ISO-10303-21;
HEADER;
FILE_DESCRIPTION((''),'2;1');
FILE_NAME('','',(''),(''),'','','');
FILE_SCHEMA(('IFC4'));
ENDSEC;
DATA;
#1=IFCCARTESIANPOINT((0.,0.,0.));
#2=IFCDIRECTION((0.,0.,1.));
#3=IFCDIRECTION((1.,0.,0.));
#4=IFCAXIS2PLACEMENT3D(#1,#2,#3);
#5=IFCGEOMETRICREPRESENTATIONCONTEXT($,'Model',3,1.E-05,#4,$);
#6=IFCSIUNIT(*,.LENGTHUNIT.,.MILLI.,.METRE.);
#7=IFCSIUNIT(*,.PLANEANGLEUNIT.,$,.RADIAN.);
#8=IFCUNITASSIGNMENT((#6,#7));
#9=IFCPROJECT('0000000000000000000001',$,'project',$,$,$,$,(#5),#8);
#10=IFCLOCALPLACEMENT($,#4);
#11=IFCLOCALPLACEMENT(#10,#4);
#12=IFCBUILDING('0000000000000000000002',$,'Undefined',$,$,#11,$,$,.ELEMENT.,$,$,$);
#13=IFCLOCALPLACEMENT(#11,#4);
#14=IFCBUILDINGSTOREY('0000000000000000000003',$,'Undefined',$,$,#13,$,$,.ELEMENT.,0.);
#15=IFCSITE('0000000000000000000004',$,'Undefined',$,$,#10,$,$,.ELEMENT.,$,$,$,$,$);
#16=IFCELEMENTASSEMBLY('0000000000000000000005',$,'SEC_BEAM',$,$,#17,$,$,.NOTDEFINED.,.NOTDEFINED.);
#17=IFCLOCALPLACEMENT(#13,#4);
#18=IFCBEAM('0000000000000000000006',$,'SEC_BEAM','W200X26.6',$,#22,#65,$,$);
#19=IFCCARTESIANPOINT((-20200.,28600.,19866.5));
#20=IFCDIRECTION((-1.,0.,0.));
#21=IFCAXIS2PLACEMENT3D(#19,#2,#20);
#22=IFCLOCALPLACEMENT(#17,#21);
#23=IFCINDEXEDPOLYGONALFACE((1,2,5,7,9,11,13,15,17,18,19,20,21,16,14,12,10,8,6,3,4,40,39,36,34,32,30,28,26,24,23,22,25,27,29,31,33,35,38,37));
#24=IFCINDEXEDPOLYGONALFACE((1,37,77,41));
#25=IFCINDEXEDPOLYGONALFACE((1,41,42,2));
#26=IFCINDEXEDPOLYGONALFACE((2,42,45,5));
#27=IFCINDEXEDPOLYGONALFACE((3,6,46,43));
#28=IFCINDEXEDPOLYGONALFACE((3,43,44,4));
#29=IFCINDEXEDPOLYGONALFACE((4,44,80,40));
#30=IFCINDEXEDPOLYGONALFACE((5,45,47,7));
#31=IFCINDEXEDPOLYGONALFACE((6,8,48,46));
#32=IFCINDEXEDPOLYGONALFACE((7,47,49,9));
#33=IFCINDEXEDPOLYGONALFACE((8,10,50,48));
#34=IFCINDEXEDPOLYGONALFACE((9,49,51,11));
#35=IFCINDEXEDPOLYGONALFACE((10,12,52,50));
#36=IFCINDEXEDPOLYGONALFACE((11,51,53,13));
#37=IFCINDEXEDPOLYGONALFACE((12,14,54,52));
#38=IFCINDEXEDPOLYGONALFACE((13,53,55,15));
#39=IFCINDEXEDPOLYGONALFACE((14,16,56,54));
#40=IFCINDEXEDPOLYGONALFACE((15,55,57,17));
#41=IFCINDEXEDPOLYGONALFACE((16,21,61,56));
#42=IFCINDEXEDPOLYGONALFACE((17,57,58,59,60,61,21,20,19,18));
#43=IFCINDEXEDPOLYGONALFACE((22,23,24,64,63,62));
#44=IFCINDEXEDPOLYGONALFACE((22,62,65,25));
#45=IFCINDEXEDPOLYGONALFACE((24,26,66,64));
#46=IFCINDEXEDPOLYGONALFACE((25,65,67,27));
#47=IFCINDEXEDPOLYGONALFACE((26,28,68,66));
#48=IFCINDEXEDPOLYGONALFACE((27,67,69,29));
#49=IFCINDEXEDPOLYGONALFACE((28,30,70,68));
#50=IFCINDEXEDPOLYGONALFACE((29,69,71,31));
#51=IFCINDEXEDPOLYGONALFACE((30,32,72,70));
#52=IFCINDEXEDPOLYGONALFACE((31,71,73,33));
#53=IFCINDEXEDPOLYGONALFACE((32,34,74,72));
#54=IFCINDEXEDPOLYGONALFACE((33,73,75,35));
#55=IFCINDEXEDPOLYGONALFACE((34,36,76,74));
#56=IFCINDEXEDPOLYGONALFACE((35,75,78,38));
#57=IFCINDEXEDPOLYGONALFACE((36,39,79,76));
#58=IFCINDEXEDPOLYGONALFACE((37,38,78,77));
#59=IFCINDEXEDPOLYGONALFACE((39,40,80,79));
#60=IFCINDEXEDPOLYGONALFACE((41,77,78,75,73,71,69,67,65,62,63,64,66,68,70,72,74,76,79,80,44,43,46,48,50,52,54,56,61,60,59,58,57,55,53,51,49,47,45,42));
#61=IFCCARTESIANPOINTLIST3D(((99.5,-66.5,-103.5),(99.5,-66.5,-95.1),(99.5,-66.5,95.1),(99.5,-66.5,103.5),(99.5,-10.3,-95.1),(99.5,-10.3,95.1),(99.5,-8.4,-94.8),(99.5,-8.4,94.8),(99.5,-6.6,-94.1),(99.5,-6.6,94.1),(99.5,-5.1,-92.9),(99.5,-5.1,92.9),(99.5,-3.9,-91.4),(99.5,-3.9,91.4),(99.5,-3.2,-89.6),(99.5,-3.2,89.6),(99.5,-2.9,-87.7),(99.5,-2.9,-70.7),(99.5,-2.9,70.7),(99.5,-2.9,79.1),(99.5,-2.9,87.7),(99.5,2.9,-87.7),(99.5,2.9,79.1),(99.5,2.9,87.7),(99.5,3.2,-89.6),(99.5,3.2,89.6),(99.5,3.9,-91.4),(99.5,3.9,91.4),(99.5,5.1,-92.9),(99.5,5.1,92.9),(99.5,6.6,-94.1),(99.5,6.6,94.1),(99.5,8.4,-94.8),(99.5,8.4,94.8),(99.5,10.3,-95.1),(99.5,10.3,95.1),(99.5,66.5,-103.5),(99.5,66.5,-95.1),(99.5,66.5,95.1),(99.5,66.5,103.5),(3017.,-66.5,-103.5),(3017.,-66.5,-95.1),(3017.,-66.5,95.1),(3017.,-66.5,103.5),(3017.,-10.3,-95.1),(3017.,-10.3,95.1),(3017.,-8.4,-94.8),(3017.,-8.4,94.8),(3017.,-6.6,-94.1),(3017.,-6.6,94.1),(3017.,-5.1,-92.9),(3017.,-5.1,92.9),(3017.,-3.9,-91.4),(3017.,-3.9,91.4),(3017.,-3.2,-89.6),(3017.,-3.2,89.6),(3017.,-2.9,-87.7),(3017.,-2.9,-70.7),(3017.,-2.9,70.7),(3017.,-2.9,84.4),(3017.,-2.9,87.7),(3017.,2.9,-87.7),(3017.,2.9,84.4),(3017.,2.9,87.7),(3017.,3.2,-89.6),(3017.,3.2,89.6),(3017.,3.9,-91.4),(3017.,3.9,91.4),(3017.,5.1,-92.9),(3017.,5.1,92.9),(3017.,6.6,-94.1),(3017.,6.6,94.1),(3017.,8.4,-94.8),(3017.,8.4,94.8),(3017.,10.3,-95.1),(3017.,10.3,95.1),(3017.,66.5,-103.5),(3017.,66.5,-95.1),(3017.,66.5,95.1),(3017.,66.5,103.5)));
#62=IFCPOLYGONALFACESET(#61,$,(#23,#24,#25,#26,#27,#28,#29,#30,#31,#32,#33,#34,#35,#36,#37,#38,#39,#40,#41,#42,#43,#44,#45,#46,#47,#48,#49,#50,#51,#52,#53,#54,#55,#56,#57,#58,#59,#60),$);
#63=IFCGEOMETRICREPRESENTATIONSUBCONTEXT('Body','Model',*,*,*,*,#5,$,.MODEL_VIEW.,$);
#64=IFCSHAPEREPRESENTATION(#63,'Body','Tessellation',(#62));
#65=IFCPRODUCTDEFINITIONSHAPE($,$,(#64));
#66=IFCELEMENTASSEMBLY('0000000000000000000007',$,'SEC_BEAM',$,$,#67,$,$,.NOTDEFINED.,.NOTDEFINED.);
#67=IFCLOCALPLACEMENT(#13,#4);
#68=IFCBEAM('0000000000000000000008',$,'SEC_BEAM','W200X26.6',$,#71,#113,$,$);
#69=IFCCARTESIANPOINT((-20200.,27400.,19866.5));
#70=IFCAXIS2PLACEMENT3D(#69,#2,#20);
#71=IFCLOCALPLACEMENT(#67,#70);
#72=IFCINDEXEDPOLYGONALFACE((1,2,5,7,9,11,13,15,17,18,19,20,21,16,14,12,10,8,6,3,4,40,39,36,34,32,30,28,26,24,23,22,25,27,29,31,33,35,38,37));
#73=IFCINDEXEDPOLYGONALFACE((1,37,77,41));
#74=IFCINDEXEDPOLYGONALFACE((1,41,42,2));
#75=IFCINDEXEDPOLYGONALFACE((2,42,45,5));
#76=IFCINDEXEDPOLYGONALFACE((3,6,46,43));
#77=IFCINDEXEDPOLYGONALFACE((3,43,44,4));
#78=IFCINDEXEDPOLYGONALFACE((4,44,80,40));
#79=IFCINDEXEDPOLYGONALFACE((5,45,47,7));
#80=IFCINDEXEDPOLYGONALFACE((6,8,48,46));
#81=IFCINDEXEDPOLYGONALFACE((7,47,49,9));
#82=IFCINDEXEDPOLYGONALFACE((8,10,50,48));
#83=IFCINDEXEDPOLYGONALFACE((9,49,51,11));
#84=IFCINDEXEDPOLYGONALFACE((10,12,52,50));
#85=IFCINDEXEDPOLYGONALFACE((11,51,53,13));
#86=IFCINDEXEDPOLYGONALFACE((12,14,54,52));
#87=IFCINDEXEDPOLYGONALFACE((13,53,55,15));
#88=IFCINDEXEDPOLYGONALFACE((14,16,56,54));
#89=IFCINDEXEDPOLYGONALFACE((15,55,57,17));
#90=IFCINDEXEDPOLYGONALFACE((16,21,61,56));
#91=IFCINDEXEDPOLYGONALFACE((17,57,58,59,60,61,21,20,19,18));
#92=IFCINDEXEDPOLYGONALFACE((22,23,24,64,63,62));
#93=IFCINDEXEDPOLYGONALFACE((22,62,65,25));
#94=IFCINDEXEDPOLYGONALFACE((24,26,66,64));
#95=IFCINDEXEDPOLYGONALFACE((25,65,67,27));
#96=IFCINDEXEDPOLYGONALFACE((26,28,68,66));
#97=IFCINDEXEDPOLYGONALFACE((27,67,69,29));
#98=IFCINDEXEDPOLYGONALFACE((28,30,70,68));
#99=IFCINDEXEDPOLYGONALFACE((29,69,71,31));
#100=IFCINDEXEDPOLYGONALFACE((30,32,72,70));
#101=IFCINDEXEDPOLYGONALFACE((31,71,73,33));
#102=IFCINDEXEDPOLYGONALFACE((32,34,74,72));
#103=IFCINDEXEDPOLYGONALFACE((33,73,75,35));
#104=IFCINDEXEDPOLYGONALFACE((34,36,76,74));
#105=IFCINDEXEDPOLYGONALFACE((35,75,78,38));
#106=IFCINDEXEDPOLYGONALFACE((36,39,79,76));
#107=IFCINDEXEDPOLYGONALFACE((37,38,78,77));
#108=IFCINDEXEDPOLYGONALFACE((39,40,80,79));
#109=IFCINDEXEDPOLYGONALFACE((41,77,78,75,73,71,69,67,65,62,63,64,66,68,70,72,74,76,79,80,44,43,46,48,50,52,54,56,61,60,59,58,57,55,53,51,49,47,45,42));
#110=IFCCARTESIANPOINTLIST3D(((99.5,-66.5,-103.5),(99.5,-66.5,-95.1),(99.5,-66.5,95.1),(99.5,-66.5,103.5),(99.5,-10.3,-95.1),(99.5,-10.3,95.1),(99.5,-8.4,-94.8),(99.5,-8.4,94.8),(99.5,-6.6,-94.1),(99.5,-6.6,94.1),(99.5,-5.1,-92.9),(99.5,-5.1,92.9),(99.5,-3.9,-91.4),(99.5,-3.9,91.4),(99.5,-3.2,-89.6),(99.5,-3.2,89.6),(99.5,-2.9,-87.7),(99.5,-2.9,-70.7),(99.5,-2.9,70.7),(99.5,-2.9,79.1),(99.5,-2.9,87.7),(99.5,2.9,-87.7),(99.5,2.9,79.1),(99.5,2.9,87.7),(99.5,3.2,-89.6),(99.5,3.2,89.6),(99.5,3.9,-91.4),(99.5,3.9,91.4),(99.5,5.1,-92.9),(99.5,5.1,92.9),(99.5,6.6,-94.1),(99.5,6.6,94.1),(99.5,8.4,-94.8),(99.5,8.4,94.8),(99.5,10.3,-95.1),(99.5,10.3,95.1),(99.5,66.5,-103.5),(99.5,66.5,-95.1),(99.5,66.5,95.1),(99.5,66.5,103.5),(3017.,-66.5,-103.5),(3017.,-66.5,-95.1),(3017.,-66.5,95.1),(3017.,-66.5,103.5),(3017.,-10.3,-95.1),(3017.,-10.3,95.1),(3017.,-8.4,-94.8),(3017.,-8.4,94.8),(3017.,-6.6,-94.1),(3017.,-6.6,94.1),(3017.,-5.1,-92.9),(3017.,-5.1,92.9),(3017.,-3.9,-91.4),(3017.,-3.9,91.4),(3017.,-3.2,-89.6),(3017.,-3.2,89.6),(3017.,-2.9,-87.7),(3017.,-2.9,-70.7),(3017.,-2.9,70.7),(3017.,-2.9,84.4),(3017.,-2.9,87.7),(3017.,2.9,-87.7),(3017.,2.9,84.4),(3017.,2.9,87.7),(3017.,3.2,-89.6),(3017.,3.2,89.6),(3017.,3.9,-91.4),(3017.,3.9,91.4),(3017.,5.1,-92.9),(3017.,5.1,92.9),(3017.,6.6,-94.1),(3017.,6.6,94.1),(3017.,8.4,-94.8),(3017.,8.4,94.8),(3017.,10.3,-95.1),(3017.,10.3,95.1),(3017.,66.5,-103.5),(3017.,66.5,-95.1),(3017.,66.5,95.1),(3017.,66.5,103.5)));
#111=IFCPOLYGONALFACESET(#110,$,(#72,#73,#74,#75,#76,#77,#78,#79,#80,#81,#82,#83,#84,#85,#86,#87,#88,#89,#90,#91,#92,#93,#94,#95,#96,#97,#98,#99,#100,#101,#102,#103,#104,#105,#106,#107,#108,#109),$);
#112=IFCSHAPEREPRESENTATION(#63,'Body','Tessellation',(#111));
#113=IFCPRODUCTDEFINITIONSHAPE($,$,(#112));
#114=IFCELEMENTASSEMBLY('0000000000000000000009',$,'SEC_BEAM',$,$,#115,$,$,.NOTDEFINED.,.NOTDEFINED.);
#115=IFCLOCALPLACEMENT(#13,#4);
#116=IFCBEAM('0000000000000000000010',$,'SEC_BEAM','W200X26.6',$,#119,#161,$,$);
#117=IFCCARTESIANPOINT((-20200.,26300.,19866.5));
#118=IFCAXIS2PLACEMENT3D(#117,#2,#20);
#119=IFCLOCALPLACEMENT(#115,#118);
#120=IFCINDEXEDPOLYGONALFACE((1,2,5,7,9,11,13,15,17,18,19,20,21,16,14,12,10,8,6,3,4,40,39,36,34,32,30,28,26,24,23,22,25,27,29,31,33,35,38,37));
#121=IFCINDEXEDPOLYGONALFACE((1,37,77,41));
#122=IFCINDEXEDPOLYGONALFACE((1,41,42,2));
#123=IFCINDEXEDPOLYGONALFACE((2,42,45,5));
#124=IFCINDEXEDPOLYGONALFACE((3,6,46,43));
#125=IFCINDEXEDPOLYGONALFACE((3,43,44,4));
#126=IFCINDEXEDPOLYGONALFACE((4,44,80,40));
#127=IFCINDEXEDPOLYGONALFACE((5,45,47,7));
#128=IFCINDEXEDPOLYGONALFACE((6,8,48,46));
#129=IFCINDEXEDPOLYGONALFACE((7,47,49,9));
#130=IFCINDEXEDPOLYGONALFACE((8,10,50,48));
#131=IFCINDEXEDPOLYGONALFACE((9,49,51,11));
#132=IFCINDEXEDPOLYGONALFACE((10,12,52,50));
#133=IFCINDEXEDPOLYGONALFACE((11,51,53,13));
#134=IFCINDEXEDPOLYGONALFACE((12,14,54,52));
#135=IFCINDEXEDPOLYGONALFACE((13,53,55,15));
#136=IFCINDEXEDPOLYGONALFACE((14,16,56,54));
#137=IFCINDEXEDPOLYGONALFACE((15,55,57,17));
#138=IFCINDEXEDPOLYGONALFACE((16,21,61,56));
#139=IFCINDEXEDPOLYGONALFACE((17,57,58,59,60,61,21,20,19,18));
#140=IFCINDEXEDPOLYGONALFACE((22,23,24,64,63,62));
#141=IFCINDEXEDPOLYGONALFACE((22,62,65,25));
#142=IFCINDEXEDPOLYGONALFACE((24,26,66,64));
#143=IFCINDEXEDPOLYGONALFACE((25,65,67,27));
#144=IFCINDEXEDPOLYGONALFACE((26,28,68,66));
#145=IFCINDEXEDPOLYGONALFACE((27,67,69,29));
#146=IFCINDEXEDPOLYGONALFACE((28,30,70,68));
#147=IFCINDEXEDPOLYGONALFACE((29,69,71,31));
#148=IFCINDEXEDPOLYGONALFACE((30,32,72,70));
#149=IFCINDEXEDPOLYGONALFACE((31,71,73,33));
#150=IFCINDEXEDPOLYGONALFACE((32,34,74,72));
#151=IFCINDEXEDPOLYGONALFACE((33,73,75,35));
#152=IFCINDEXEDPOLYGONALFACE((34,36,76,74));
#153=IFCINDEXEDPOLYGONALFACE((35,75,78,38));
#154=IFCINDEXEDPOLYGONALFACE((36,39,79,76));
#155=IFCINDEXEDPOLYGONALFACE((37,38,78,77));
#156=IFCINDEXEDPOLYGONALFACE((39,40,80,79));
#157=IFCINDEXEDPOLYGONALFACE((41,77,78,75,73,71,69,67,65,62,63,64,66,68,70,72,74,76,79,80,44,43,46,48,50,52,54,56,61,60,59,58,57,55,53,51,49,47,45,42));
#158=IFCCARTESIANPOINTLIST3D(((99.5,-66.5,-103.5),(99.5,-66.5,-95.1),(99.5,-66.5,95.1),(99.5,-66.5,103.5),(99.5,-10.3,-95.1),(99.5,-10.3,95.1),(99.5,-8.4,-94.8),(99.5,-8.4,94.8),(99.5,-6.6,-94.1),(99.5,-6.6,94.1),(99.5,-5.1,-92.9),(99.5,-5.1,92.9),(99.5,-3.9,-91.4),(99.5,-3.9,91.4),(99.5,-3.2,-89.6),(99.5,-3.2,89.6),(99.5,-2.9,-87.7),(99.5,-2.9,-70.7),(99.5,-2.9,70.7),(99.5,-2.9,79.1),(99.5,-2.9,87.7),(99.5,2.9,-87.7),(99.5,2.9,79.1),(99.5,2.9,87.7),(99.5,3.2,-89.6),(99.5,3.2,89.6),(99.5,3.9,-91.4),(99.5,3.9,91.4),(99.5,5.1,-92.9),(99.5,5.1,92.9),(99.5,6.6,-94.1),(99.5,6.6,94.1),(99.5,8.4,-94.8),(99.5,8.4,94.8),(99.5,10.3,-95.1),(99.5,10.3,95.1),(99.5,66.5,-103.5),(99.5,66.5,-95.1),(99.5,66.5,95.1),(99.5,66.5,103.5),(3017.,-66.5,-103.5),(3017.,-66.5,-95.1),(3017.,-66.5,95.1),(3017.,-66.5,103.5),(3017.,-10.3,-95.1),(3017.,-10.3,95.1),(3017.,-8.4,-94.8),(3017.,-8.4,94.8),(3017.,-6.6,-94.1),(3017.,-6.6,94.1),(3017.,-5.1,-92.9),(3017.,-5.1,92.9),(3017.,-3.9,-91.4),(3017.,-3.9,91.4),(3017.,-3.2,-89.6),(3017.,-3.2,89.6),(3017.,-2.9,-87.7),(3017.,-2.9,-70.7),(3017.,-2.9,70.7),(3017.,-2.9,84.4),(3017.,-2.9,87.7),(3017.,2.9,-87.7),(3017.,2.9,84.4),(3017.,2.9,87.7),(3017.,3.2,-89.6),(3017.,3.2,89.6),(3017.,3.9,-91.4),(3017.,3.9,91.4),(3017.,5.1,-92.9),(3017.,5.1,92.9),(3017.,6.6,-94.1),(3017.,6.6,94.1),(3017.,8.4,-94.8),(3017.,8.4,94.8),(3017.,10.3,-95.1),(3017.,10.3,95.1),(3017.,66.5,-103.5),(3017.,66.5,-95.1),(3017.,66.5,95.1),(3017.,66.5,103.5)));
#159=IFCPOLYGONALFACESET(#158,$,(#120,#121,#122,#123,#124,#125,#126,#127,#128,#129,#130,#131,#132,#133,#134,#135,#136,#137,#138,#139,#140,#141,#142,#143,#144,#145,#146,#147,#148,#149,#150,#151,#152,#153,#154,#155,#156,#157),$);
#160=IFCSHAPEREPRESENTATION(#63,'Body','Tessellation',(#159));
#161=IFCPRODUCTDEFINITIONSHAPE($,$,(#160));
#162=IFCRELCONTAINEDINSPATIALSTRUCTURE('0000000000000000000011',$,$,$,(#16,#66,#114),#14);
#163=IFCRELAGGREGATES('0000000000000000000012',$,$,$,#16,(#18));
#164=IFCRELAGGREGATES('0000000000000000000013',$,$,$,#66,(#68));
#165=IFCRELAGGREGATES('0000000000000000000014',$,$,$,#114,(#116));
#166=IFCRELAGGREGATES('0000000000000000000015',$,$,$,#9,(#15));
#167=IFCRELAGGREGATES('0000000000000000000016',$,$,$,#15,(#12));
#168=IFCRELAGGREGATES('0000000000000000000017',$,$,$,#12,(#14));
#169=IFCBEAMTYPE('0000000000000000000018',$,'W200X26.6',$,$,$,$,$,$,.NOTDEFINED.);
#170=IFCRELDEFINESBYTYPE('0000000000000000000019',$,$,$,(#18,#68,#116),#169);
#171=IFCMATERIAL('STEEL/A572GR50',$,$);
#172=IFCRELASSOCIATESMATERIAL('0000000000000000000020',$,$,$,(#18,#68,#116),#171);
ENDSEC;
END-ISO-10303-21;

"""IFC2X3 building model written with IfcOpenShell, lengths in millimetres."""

from ifc_helpers import new_model, si_unit, frame, origin_with_axes, origin_2d_with_axis, place, context, subcontext, project, spatial, polyline, rectangle, i_section, outline, extrude, boolean, halfspace, material, type_object, element, aggregate, save


model = new_model("IFC2X3")

# Units and contexts
model_context = context("Model", 3, precision=1e-05, world=origin_with_axes())
body_context = subcontext(model_context, "Body", "Model", "MODEL_VIEW")
ifc_project = project(units=[si_unit("LENGTHUNIT", "METRE", prefix="MILLI"), si_unit("PLANEANGLEUNIT", "RADIAN")], contexts=[model_context])

# Site, building, storey
site_placement = place(None, origin_with_axes())
site = spatial("IfcSite", under=ifc_project, at=site_placement, Name="Undefined", CompositionType="ELEMENT")
building_placement = place(site_placement, origin_with_axes())
building = spatial("IfcBuilding", under=site, at=building_placement, Name="Undefined", CompositionType="ELEMENT")
storey_placement = place(building_placement, origin_with_axes())
storey = spatial("IfcBuildingStorey", under=building, at=storey_placement, Name="Undefined", CompositionType="ELEMENT", Elevation=0.0)

# Element assemblies, beams
ifc_material_1 = material(Name="STEEL/A572GR50")
assembly_1_placement = place(storey_placement, origin_with_axes())
assembly_1 = element("IfcElementAssembly", 1, at=assembly_1_placement, inside=storey, Name="SEC_BEAM", AssemblyPlace="NOTDEFINED", PredefinedType="NOTDEFINED")
beam_type_1 = type_object("IfcBeamType", Name="W200X26.6", PredefinedType="NOTDEFINED")
beam_1_placement = place(assembly_1_placement, frame((-20200.0, 28600.0, 19866.5), z_axis=(0.0, 0.0, 1.0), x_axis=(-1.0, 0.0, 0.0)))
beam_1 = element("IfcBeam", 2, at=beam_1_placement, type_object=beam_type_1, material=ifc_material_1, Name="SEC_BEAM", Description="W200X26.6", context=body_context, shape_type="CSG", body=[
    boolean("DIFFERENCE", boolean("DIFFERENCE", boolean("DIFFERENCE", boolean("DIFFERENCE", boolean("DIFFERENCE", boolean("DIFFERENCE", extrude(i_section(OverallWidth=133.0, OverallDepth=207.0, WebThickness=5.8, FlangeThickness=8.4, FilletRadius=7.4, at=origin_2d_with_axis()), frame((3100.0, 0.0, 0.0), z_axis=(-1.0, 0.0, 0.0), x_axis=(0.0, -1.0, 0.0)), (0.0, 0.0, 1.0), 3100.0), extrude(outline(polyline([(0.0, 0.0), (34.4, 0.0), (34.4, 10.0), (0.0, 10.0), (0.0, 0.0)])), frame((99.5, 76.5, 79.1), z_axis=(0.0, -1.0, 0.0), x_axis=(0.0, 0.0, 1.0)), (0.0, 0.0, 1.0), 153.0)), extrude(rectangle(XDim=165.1, YDim=165.1, at=origin_2d_with_axis()), frame((87.0, -85.5, 70.7), z_axis=(0.0, 0.0, -1.0), x_axis=(1.0, 0.0, 0.0)), (0.0, 0.0, 1.0), 141.5)), extrude(outline(polyline([(0.0, 0.0), (29.1, 0.0), (29.1, 10.0), (0.0, 10.0), (0.0, 0.0)])), frame((3017.0, -76.5, 84.4), z_axis=(0.0, 1.0, 0.0), x_axis=(0.0, 0.0, 1.0)), (0.0, 0.0, 1.0), 153.0)), extrude(rectangle(XDim=149.9, YDim=149.9, at=origin_2d_with_axis()), frame((3022.0, -77.9, 70.7), z_axis=(0.0, 0.0, -1.0), x_axis=(-1.0, 0.0, 0.0)), (0.0, 0.0, 1.0), 141.5)), halfspace(frame((3017.0, 0.0, 203.5), z_axis=(1.0, 0.0, 0.0), x_axis=(0.0, 1.0, 0.0)), False)), halfspace(frame((99.5, 0.0, 203.5), z_axis=(-1.0, 0.0, 0.0), x_axis=(0.0, -1.0, 0.0)), False)),
])
assembly_2_placement = place(storey_placement, origin_with_axes())
assembly_2 = element("IfcElementAssembly", 3, at=assembly_2_placement, inside=storey, Name="SEC_BEAM", AssemblyPlace="NOTDEFINED", PredefinedType="NOTDEFINED")
beam_2_placement = place(assembly_2_placement, frame((-20200.0, 27400.0, 19866.5), z_axis=(0.0, 0.0, 1.0), x_axis=(-1.0, 0.0, 0.0)))
beam_2 = element("IfcBeam", 4, at=beam_2_placement, type_object=beam_type_1, material=ifc_material_1, Name="SEC_BEAM", Description="W200X26.6", context=body_context, shape_type="CSG", body=[
    boolean("DIFFERENCE", boolean("DIFFERENCE", boolean("DIFFERENCE", boolean("DIFFERENCE", boolean("DIFFERENCE", boolean("DIFFERENCE", extrude(i_section(OverallWidth=133.0, OverallDepth=207.0, WebThickness=5.8, FlangeThickness=8.4, FilletRadius=7.4, at=origin_2d_with_axis()), frame((3100.0, 0.0, 0.0), z_axis=(-1.0, 0.0, 0.0), x_axis=(0.0, -1.0, 0.0)), (0.0, 0.0, 1.0), 3100.0), extrude(outline(polyline([(0.0, 0.0), (34.4, 0.0), (34.4, 10.0), (0.0, 10.0), (0.0, 0.0)])), frame((99.5, 76.5, 79.1), z_axis=(0.0, -1.0, 0.0), x_axis=(0.0, 0.0, 1.0)), (0.0, 0.0, 1.0), 153.0)), extrude(rectangle(XDim=165.1, YDim=165.1, at=origin_2d_with_axis()), frame((87.0, -85.5, 70.7), z_axis=(0.0, 0.0, -1.0), x_axis=(1.0, 0.0, 0.0)), (0.0, 0.0, 1.0), 141.5)), extrude(outline(polyline([(0.0, 0.0), (29.1, 0.0), (29.1, 10.0), (0.0, 10.0), (0.0, 0.0)])), frame((3017.0, -76.5, 84.4), z_axis=(0.0, 1.0, 0.0), x_axis=(0.0, 0.0, 1.0)), (0.0, 0.0, 1.0), 153.0)), extrude(rectangle(XDim=149.9, YDim=149.9, at=origin_2d_with_axis()), frame((3022.0, -77.9, 70.7), z_axis=(0.0, 0.0, -1.0), x_axis=(-1.0, 0.0, 0.0)), (0.0, 0.0, 1.0), 141.5)), halfspace(frame((3017.0, 0.0, 203.5), z_axis=(1.0, 0.0, 0.0), x_axis=(0.0, 1.0, 0.0)), False)), halfspace(frame((99.5, 0.0, 203.5), z_axis=(-1.0, 0.0, 0.0), x_axis=(0.0, -1.0, 0.0)), False)),
])
assembly_3_placement = place(storey_placement, origin_with_axes())
assembly_3 = element("IfcElementAssembly", 5, at=assembly_3_placement, inside=storey, Name="SEC_BEAM", AssemblyPlace="NOTDEFINED", PredefinedType="NOTDEFINED")
beam_3_placement = place(assembly_3_placement, frame((-20200.0, 26300.0, 19866.5), z_axis=(0.0, 0.0, 1.0), x_axis=(-1.0, 0.0, 0.0)))
beam_3 = element("IfcBeam", 6, at=beam_3_placement, type_object=beam_type_1, material=ifc_material_1, Name="SEC_BEAM", Description="W200X26.6", context=body_context, shape_type="CSG", body=[
    boolean("DIFFERENCE", boolean("DIFFERENCE", boolean("DIFFERENCE", boolean("DIFFERENCE", boolean("DIFFERENCE", boolean("DIFFERENCE", extrude(i_section(OverallWidth=133.0, OverallDepth=207.0, WebThickness=5.8, FlangeThickness=8.4, FilletRadius=7.4, at=origin_2d_with_axis()), frame((3100.0, 0.0, 0.0), z_axis=(-1.0, 0.0, 0.0), x_axis=(0.0, -1.0, 0.0)), (0.0, 0.0, 1.0), 3100.0), extrude(outline(polyline([(0.0, 0.0), (34.4, 0.0), (34.4, 10.0), (0.0, 10.0), (0.0, 0.0)])), frame((99.5, 76.5, 79.1), z_axis=(0.0, -1.0, 0.0), x_axis=(0.0, 0.0, 1.0)), (0.0, 0.0, 1.0), 153.0)), extrude(rectangle(XDim=165.1, YDim=165.1, at=origin_2d_with_axis()), frame((87.0, -85.5, 70.7), z_axis=(0.0, 0.0, -1.0), x_axis=(1.0, 0.0, 0.0)), (0.0, 0.0, 1.0), 141.5)), extrude(outline(polyline([(0.0, 0.0), (29.1, 0.0), (29.1, 10.0), (0.0, 10.0), (0.0, 0.0)])), frame((3017.0, -76.5, 84.4), z_axis=(0.0, 1.0, 0.0), x_axis=(0.0, 0.0, 1.0)), (0.0, 0.0, 1.0), 153.0)), extrude(rectangle(XDim=149.9, YDim=149.9, at=origin_2d_with_axis()), frame((3022.0, -77.9, 70.7), z_axis=(0.0, 0.0, -1.0), x_axis=(-1.0, 0.0, 0.0)), (0.0, 0.0, 1.0), 141.5)), halfspace(frame((3017.0, 0.0, 203.5), z_axis=(1.0, 0.0, 0.0), x_axis=(0.0, 1.0, 0.0)), False)), halfspace(frame((99.5, 0.0, 203.5), z_axis=(-1.0, 0.0, 0.0), x_axis=(0.0, -1.0, 0.0)), False)),
])

aggregate(assembly_1, [beam_1])
aggregate(assembly_2, [beam_2])
aggregate(assembly_3, [beam_3])

save(model, "model.ifc")
